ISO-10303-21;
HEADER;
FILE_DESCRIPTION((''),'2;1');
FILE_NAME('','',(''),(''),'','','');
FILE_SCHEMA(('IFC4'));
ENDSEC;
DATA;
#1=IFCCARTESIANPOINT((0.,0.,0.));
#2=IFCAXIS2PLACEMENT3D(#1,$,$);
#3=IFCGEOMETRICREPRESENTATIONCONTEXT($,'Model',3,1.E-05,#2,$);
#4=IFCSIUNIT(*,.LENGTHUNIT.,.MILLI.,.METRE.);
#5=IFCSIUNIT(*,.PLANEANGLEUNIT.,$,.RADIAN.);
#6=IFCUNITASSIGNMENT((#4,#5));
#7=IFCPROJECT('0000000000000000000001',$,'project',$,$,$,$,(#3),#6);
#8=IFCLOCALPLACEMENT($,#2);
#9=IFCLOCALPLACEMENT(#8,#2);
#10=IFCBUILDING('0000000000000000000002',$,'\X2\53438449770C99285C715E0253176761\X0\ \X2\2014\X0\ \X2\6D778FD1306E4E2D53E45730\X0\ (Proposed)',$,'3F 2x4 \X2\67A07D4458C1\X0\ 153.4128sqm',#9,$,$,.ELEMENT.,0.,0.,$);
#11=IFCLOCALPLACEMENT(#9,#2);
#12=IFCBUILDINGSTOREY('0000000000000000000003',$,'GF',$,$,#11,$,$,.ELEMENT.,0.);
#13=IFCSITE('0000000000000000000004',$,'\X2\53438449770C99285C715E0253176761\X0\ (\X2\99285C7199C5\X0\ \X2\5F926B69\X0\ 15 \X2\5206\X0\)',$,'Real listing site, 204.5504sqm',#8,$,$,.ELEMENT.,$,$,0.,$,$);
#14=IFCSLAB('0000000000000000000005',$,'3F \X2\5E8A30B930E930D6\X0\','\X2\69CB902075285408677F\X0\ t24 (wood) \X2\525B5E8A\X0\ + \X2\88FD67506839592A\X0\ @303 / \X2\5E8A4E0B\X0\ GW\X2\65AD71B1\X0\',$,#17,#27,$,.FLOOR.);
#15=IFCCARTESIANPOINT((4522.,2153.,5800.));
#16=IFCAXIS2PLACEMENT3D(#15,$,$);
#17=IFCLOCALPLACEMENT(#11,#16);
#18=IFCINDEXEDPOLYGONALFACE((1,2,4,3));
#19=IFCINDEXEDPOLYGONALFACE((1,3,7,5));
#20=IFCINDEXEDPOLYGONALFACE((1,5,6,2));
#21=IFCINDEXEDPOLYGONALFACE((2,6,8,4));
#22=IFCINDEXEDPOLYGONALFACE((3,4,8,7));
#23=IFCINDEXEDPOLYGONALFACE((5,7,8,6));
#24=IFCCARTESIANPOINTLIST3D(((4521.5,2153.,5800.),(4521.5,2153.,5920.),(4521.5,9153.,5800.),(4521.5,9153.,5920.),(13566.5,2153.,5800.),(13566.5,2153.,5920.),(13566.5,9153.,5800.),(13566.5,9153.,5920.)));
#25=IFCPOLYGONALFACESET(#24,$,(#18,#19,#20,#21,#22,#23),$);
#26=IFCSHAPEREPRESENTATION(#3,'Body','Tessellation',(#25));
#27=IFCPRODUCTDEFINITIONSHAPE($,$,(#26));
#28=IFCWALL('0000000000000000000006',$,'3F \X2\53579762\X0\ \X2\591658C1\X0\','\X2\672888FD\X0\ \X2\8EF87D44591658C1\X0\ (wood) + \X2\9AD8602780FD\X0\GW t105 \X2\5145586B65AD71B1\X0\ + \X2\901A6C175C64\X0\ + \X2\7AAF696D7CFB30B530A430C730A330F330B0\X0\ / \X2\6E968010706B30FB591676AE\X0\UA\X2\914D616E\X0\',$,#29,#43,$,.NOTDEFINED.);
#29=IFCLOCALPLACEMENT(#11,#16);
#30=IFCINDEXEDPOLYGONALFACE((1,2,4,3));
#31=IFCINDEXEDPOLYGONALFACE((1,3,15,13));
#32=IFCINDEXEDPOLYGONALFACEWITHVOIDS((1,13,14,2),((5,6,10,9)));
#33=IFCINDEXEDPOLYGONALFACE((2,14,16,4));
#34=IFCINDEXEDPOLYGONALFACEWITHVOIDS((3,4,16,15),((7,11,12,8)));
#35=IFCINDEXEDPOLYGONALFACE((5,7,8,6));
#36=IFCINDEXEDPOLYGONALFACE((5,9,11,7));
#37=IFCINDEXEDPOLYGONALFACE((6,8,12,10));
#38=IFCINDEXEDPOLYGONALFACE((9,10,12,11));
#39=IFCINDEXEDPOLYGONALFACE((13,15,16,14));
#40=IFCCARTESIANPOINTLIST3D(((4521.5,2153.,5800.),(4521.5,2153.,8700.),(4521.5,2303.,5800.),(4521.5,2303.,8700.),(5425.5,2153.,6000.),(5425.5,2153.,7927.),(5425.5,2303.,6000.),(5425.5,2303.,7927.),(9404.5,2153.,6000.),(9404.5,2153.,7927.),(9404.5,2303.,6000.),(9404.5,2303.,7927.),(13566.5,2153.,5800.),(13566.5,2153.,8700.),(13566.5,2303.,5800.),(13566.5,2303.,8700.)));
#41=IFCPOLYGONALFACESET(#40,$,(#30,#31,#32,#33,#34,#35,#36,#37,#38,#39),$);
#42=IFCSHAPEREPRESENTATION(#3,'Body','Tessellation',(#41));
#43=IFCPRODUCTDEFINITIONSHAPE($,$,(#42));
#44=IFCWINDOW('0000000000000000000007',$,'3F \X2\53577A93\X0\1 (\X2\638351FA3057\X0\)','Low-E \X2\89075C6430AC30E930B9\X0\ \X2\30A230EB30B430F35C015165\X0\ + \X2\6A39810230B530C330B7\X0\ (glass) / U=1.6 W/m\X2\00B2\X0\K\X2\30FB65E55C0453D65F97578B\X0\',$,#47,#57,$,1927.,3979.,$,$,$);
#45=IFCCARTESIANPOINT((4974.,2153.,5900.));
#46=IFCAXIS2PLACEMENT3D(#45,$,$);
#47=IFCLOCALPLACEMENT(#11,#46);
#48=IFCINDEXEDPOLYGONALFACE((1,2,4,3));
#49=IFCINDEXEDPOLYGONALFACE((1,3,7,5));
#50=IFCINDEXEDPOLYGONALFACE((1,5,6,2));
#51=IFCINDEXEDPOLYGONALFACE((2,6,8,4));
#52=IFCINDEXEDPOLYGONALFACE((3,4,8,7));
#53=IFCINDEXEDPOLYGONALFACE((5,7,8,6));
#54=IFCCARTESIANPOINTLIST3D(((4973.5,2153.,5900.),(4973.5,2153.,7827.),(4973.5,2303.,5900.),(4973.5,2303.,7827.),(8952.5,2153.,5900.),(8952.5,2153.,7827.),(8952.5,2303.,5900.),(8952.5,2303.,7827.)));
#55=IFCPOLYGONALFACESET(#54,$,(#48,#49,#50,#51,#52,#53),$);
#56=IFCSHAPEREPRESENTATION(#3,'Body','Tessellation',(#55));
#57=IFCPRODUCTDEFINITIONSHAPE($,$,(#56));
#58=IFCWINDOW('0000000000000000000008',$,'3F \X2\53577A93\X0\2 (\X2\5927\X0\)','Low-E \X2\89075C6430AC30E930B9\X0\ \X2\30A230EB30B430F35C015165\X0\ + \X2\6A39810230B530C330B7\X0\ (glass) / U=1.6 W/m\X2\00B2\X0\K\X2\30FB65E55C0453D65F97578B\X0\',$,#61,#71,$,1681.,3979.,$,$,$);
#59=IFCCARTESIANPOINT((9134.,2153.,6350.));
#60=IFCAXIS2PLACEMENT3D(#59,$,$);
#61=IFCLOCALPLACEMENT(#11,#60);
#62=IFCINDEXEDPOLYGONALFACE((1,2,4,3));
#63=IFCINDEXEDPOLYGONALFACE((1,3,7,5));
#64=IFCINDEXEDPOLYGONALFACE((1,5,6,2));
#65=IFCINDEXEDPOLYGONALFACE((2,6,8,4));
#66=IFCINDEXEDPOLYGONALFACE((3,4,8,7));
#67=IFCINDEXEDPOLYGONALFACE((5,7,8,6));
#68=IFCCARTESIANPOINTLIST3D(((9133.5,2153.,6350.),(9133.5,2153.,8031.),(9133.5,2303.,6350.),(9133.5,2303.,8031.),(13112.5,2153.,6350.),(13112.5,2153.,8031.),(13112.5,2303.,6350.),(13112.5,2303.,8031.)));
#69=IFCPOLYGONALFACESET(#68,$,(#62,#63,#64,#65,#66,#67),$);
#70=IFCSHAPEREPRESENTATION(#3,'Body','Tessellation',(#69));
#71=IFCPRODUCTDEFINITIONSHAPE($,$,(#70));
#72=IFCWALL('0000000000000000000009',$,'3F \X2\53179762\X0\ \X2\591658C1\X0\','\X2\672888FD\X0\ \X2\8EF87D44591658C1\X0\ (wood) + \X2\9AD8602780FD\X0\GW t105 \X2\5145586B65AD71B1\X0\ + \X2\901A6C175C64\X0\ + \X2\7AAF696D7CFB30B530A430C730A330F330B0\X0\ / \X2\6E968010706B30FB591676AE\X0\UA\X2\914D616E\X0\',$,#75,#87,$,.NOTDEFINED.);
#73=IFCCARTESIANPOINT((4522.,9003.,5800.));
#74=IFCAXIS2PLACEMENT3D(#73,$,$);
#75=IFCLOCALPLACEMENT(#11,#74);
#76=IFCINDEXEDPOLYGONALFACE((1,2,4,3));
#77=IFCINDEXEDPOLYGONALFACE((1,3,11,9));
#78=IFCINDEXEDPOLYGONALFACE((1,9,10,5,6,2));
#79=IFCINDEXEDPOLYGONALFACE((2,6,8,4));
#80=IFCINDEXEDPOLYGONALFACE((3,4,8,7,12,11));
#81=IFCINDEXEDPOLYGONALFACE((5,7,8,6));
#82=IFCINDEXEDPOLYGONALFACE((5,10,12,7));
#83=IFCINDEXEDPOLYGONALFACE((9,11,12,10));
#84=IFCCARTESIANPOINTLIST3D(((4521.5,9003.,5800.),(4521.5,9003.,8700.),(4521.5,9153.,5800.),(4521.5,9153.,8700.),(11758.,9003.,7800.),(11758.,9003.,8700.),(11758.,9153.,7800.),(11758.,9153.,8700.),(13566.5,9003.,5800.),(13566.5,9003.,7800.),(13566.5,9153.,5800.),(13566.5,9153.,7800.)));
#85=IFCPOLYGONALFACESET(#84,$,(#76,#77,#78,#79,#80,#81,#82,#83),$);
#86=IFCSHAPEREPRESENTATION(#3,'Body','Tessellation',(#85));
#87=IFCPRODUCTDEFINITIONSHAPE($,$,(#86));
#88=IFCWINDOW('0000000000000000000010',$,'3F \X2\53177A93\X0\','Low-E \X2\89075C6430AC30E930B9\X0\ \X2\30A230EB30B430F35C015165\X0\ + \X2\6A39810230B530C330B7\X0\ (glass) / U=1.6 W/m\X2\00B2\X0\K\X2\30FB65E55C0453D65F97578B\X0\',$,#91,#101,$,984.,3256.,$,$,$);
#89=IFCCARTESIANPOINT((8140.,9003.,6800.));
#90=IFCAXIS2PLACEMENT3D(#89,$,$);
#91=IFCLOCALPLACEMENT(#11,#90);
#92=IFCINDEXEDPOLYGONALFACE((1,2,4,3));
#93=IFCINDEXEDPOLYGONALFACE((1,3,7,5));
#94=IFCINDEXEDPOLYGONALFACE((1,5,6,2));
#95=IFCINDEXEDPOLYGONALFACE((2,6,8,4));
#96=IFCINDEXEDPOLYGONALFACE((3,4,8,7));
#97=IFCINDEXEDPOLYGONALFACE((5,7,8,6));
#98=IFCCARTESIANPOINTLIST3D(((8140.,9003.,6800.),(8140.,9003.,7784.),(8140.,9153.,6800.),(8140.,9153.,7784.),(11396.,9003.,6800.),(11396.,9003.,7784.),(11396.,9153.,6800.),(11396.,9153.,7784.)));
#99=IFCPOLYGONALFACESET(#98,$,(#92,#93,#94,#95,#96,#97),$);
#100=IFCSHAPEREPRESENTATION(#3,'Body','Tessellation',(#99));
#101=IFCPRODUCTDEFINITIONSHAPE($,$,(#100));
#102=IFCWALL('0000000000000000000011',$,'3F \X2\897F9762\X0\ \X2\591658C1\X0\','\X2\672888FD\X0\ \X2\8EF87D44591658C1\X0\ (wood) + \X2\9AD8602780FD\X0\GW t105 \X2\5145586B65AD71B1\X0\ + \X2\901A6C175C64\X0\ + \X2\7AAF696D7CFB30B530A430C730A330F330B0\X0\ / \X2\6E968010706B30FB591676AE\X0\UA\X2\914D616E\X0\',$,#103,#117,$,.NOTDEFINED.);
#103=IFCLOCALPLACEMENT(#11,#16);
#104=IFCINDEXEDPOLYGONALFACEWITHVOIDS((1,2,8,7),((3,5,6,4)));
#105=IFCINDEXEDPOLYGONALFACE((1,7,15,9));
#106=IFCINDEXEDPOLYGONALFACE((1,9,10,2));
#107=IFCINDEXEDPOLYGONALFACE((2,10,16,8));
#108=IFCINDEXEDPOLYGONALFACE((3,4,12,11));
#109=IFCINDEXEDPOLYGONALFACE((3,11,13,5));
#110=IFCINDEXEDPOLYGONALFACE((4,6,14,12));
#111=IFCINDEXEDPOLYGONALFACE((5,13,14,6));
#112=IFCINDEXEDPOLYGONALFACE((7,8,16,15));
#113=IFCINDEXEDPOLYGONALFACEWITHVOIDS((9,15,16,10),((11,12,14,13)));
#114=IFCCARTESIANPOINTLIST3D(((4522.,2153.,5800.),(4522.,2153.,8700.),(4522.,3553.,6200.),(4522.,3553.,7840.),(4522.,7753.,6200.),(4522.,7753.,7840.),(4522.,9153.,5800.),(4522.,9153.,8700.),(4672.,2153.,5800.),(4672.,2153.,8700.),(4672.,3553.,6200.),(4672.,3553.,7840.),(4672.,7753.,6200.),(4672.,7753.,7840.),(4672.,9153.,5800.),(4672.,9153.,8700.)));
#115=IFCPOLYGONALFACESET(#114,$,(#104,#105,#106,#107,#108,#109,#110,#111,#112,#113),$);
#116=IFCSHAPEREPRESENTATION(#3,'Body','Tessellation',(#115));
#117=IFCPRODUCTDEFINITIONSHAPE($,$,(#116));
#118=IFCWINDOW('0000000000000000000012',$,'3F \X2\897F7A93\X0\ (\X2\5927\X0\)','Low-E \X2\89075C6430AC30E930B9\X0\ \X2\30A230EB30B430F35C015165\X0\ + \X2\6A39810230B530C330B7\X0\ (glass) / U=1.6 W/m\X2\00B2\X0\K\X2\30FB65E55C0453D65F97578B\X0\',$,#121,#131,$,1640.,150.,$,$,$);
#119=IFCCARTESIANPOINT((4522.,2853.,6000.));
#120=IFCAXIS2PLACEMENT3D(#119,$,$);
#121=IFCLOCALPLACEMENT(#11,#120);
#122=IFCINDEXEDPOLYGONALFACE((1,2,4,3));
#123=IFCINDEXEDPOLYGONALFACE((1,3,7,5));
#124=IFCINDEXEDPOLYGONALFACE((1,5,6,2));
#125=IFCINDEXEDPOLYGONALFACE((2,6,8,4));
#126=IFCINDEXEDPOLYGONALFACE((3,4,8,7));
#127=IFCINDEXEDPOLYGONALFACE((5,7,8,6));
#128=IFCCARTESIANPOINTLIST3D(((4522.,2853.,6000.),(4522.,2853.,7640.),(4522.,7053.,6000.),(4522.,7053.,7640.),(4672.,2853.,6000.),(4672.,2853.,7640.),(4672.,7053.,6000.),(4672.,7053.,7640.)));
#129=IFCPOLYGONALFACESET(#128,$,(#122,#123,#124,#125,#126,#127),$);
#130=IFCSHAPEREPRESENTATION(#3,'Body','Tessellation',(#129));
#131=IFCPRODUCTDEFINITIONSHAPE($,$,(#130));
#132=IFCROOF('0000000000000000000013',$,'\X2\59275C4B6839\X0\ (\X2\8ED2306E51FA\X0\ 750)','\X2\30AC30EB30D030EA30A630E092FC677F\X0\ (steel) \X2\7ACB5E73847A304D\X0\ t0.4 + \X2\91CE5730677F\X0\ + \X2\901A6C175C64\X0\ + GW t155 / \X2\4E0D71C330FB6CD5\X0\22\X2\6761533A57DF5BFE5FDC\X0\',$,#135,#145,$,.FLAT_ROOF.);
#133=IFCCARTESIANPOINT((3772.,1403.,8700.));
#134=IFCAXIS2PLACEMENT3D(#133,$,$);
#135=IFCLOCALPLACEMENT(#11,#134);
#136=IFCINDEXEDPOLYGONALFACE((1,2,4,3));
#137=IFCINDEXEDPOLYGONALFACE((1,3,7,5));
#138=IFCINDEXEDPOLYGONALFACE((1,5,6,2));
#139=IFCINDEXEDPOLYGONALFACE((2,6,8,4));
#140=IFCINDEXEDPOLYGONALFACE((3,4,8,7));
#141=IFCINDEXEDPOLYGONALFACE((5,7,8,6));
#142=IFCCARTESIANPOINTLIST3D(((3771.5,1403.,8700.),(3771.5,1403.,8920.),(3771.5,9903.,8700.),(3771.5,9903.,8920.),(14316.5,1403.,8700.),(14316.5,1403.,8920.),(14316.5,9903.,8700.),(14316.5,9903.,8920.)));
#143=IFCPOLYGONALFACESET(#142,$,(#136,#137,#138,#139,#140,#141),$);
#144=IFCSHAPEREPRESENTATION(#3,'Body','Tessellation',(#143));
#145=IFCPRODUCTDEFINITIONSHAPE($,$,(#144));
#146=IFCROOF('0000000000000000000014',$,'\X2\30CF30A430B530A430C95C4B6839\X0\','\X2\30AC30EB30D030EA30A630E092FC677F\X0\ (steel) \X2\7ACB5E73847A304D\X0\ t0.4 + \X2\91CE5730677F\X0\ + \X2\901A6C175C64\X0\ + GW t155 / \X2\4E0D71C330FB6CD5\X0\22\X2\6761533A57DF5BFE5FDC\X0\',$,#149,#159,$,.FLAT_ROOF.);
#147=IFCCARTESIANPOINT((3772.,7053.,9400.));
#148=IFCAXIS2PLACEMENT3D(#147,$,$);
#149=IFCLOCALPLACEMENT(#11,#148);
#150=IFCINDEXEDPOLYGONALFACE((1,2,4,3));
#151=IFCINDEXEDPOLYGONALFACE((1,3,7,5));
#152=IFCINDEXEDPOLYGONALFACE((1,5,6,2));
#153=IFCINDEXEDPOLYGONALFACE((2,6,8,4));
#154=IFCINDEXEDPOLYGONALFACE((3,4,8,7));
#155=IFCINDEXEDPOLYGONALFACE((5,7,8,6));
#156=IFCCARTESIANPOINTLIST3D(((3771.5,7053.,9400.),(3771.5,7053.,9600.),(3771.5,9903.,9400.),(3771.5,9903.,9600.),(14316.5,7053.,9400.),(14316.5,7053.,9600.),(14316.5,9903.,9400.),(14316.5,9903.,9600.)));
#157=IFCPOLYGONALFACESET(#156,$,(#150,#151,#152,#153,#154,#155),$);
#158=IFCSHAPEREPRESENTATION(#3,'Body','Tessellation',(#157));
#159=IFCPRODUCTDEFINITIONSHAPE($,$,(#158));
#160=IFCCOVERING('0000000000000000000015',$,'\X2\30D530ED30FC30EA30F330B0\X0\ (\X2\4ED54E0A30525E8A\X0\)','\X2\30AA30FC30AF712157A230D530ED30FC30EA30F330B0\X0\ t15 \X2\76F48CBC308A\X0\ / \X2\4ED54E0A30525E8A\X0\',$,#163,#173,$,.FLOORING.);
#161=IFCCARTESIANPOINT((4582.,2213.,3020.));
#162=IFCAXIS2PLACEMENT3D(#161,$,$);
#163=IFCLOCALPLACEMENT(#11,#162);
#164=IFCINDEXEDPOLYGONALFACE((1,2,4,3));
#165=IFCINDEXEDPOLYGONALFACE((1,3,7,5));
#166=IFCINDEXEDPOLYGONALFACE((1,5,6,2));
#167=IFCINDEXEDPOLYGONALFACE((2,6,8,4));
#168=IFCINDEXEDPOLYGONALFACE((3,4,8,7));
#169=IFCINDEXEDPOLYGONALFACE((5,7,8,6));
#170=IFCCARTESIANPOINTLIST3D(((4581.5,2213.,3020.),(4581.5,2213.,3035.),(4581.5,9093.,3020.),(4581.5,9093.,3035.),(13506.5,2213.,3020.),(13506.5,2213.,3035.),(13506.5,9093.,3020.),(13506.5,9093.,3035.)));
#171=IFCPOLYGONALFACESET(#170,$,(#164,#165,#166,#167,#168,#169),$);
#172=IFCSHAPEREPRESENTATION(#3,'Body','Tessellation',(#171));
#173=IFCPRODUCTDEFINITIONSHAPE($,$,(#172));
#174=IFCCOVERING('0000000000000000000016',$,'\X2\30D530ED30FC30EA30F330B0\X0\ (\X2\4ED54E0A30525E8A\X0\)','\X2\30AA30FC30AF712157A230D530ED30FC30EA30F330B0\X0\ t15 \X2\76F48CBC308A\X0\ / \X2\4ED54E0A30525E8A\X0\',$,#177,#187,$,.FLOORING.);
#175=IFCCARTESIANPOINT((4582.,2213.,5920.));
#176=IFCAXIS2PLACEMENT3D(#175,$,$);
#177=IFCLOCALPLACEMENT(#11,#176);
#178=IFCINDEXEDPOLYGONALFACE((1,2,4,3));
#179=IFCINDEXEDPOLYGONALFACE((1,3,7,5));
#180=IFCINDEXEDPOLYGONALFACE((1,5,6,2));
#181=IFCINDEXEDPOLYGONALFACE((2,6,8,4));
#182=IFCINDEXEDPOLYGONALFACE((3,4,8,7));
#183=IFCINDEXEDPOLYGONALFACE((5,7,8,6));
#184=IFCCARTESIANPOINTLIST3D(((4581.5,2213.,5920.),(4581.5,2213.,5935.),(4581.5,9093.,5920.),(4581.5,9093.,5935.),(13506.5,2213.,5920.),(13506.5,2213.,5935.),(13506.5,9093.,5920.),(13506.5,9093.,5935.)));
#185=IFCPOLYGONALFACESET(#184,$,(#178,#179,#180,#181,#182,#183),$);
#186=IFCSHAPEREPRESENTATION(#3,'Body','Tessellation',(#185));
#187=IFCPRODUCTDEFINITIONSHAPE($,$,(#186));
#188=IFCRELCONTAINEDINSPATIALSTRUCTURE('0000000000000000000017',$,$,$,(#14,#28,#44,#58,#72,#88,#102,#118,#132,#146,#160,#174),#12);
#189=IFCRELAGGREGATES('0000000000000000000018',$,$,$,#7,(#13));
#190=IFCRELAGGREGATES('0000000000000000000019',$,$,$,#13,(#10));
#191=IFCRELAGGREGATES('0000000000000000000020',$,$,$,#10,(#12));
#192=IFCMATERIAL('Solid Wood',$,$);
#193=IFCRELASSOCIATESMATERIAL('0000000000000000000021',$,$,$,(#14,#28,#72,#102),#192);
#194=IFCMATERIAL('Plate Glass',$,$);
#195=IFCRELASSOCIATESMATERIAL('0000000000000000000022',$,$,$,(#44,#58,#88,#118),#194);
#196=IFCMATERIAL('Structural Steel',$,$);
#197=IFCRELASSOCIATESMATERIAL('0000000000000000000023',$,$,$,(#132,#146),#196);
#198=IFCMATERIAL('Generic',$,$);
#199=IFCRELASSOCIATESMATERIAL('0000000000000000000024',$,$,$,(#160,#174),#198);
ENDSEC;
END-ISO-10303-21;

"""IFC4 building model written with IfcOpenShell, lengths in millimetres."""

from ifc_helpers import new_model, si_unit, frame, frame_2d, origin, place, context, project, spatial, rectangle, extrude, material, element, fill, save


model = new_model("IFC4")

# Units and contexts
model_context = context("Model", 3, precision=1e-05, world=origin())
ifc_project = project(units=[si_unit("LENGTHUNIT", "METRE", prefix="MILLI"), si_unit("PLANEANGLEUNIT", "RADIAN")], contexts=[model_context])

# Site, building, storey
site_placement = place(None, origin())
site = spatial("IfcSite", under=ifc_project, at=site_placement, Name="千葉県館山市北条 (館山駅 徒歩 15 分)", ObjectType="Real listing site, 204.5504sqm", CompositionType="ELEMENT", RefElevation=0.0)
building_placement = place(site_placement, origin())
building = spatial("IfcBuilding", under=site, at=building_placement, Name="千葉県館山市北条 — 海近の中古地 (Proposed)", ObjectType="3F 2x4 枠組壁 153.4128sqm", CompositionType="ELEMENT", ElevationOfRefHeight=0.0, ElevationOfTerrain=0.0)
storey_placement = place(building_placement, origin())
storey = spatial("IfcBuildingStorey", under=building, at=storey_placement, Name="GF", CompositionType="ELEMENT", Elevation=0.0)

# Slab
ifc_material_1 = material(Name="Solid Wood")
slab_placement = place(storey_placement, frame((4522.0, 2153.0, 5800.0)))
element("IfcSlab", 1, at=slab_placement, inside=storey, material=ifc_material_1, Name="3F 床スラブ", Description="構造用合板 t24 (wood) 剛床 + 製材根太 @303 / 床下 GW断熱", PredefinedType="FLOOR", context=model_context, shape_type="SweptSolid", body=[
    extrude(rectangle(XDim=9045.0, YDim=7000.0, at=frame_2d((4522.0, 3500.0))), frame((4522.0, 2153.0, 5800.0)), (0.0, 0.0, 1.0), 120.0),
])

# Wall, openings, windows
wall_1_placement = place(storey_placement, frame((4522.0, 2153.0, 5800.0)))
wall_1 = element("IfcWall", 2, at=wall_1_placement, inside=storey, material=ifc_material_1, Name="3F 南面 外壁", Description="木製 軸組外壁 (wood) + 高性能GW t105 充填断熱 + 通気層 + 窯業系サイディング / 準耐火・外皮UA配慮", PredefinedType="NOTDEFINED", context=model_context, shape_type="SweptSolid", body=[
    extrude(rectangle(XDim=9045.0, YDim=150.0, at=frame_2d((4522.0, 75.0))), frame((4522.0, 2153.0, 5800.0)), (0.0, 0.0, 1.0), 2900.0),
])
opening_1_placement = place(storey_placement, frame((4974.0, 2153.0, 5900.0)))
opening_1 = element("IfcOpeningElement", 3, at=opening_1_placement, cuts=wall_1, PredefinedType="NOTDEFINED", context=model_context, shape_type="SweptSolid", body=[
    extrude(rectangle(XDim=3979.0, YDim=150.0, at=frame_2d((1989.0, 75.0))), frame((4974.0, 2153.0, 5900.0)), (0.0, 0.0, 1.0), 1927.0),
])
opening_2_placement = place(storey_placement, frame((9134.0, 2153.0, 6350.0)))
opening_2 = element("IfcOpeningElement", 4, at=opening_2_placement, cuts=wall_1, PredefinedType="NOTDEFINED", context=model_context, shape_type="SweptSolid", body=[
    extrude(rectangle(XDim=3979.0, YDim=150.0, at=frame_2d((1989.0, 75.0))), frame((9134.0, 2153.0, 6350.0)), (0.0, 0.0, 1.0), 1681.0),
])
ifc_material_2 = material(Name="Plate Glass")
window_1_placement = place(storey_placement, frame((4974.0, 2153.0, 5900.0)))
window_1 = element("IfcWindow", 5, at=window_1_placement, inside=storey, material=ifc_material_2, Name="3F 南窓1 (掃出し)", Description="Low-E 複層ガラス アルゴン封入 + 樹脂サッシ (glass) / U=1.6 W/m²K・日射取得型", OverallHeight=1927.0, OverallWidth=3979.0, context=model_context, shape_type="SweptSolid", body=[
    extrude(rectangle(XDim=3979.0, YDim=150.0, at=frame_2d((1989.0, 75.0))), frame((4974.0, 2153.0, 5900.0)), (0.0, 0.0, 1.0), 1927.0),
])
fill(opening_1, window_1)
window_2_placement = place(storey_placement, frame((9134.0, 2153.0, 6350.0)))
window_2 = element("IfcWindow", 6, at=window_2_placement, inside=storey, material=ifc_material_2, Name="3F 南窓2 (大)", Description="Low-E 複層ガラス アルゴン封入 + 樹脂サッシ (glass) / U=1.6 W/m²K・日射取得型", OverallHeight=1681.0, OverallWidth=3979.0, context=model_context, shape_type="SweptSolid", body=[
    extrude(rectangle(XDim=3979.0, YDim=150.0, at=frame_2d((1989.0, 75.0))), frame((9134.0, 2153.0, 6350.0)), (0.0, 0.0, 1.0), 1681.0),
])
fill(opening_2, window_2)

# Walls, openings, windows
wall_2_placement = place(storey_placement, frame((4522.0, 9003.0, 5800.0)))
wall_2 = element("IfcWall", 7, at=wall_2_placement, inside=storey, material=ifc_material_1, Name="3F 北面 外壁", Description="木製 軸組外壁 (wood) + 高性能GW t105 充填断熱 + 通気層 + 窯業系サイディング / 準耐火・外皮UA配慮", PredefinedType="NOTDEFINED", context=model_context, shape_type="SweptSolid", body=[
    extrude(rectangle(XDim=9045.0, YDim=150.0, at=frame_2d((4522.0, 75.0))), frame((4522.0, 9003.0, 5800.0)), (0.0, 0.0, 1.0), 2900.0),
])
opening_3_placement = place(storey_placement, frame((8140.0, 9003.0, 6800.0)))
opening_3 = element("IfcOpeningElement", 8, at=opening_3_placement, cuts=wall_2, PredefinedType="NOTDEFINED", context=model_context, shape_type="SweptSolid", body=[
    extrude(rectangle(XDim=3256.0, YDim=150.0, at=frame_2d((1628.0, 75.0))), frame((8140.0, 9003.0, 6800.0)), (0.0, 0.0, 1.0), 984.0),
])
window_3_placement = place(storey_placement, frame((8140.0, 9003.0, 6800.0)))
window_3 = element("IfcWindow", 9, at=window_3_placement, inside=storey, material=ifc_material_2, Name="3F 北窓", Description="Low-E 複層ガラス アルゴン封入 + 樹脂サッシ (glass) / U=1.6 W/m²K・日射取得型", OverallHeight=984.0, OverallWidth=3256.0, context=model_context, shape_type="SweptSolid", body=[
    extrude(rectangle(XDim=3256.0, YDim=150.0, at=frame_2d((1628.0, 75.0))), frame((8140.0, 9003.0, 6800.0)), (0.0, 0.0, 1.0), 984.0),
])
fill(opening_3, window_3)
wall_3_placement = place(storey_placement, frame((4522.0, 2153.0, 5800.0)))
wall_3 = element("IfcWall", 10, at=wall_3_placement, inside=storey, material=ifc_material_1, Name="3F 西面 外壁", Description="木製 軸組外壁 (wood) + 高性能GW t105 充填断熱 + 通気層 + 窯業系サイディング / 準耐火・外皮UA配慮", PredefinedType="NOTDEFINED", context=model_context, shape_type="SweptSolid", body=[
    extrude(rectangle(XDim=150.0, YDim=7000.0, at=frame_2d((75.0, 3500.0))), frame((4522.0, 2153.0, 5800.0)), (0.0, 0.0, 1.0), 2900.0),
])
opening_4_placement = place(storey_placement, frame((4522.0, 2853.0, 6000.0)))
opening_4 = element("IfcOpeningElement", 11, at=opening_4_placement, cuts=wall_3, PredefinedType="NOTDEFINED", context=model_context, shape_type="SweptSolid", body=[
    extrude(rectangle(XDim=150.0, YDim=4200.0, at=frame_2d((75.0, 2100.0))), frame((4522.0, 2853.0, 6000.0)), (0.0, 0.0, 1.0), 1640.0),
])
window_4_placement = place(storey_placement, frame((4522.0, 2853.0, 6000.0)))
window_4 = element("IfcWindow", 12, at=window_4_placement, inside=storey, material=ifc_material_2, Name="3F 西窓 (大)", Description="Low-E 複層ガラス アルゴン封入 + 樹脂サッシ (glass) / U=1.6 W/m²K・日射取得型", OverallHeight=1640.0, OverallWidth=150.0, context=model_context, shape_type="SweptSolid", body=[
    extrude(rectangle(XDim=150.0, YDim=4200.0, at=frame_2d((75.0, 2100.0))), frame((4522.0, 2853.0, 6000.0)), (0.0, 0.0, 1.0), 1640.0),
])
fill(opening_4, window_4)

# Roofs
ifc_material_3 = material(Name="Structural Steel")
roof_1_placement = place(storey_placement, frame((3772.0, 1403.0, 8700.0)))
element("IfcRoof", 13, at=roof_1_placement, inside=storey, material=ifc_material_3, Name="大屋根 (軒の出 750)", Description="ガルバリウム鋼板 (steel) 立平葺き t0.4 + 野地板 + 通気層 + GW t155 / 不燃・法22条区域対応", PredefinedType="FLAT_ROOF", context=model_context, shape_type="SweptSolid", body=[
    extrude(rectangle(XDim=10545.0, YDim=8500.0, at=frame_2d((5272.0, 4250.0))), frame((3772.0, 1403.0, 8700.0)), (0.0, 0.0, 1.0), 220.0),
])
roof_2_placement = place(storey_placement, frame((3772.0, 7053.0, 9400.0)))
element("IfcRoof", 14, at=roof_2_placement, inside=storey, material=ifc_material_3, Name="ハイサイド屋根", Description="ガルバリウム鋼板 (steel) 立平葺き t0.4 + 野地板 + 通気層 + GW t155 / 不燃・法22条区域対応", PredefinedType="FLAT_ROOF", context=model_context, shape_type="SweptSolid", body=[
    extrude(rectangle(XDim=10545.0, YDim=2850.0, at=frame_2d((5272.0, 1425.0))), frame((3772.0, 7053.0, 9400.0)), (0.0, 0.0, 1.0), 200.0),
])

# Coverings
ifc_material_4 = material(Name="Generic")
covering_1_placement = place(storey_placement, frame((4582.0, 2213.0, 3020.0)))
element("IfcCovering", 15, at=covering_1_placement, inside=storey, material=ifc_material_4, Name="フローリング (仕上げ床)", Description="オーク無垢フローリング t15 直貼り / 仕上げ床", PredefinedType="FLOORING", context=model_context, shape_type="SweptSolid", body=[
    extrude(rectangle(XDim=8925.0, YDim=6880.0, at=frame_2d((4462.0, 3440.0))), frame((4582.0, 2213.0, 3020.0)), (0.0, 0.0, 1.0), 15.0),
])
covering_2_placement = place(storey_placement, frame((4582.0, 2213.0, 5920.0)))
element("IfcCovering", 16, at=covering_2_placement, inside=storey, material=ifc_material_4, Name="フローリング (仕上げ床)", Description="オーク無垢フローリング t15 直貼り / 仕上げ床", PredefinedType="FLOORING", context=model_context, shape_type="SweptSolid", body=[
    extrude(rectangle(XDim=8925.0, YDim=6880.0, at=frame_2d((4462.0, 3440.0))), frame((4582.0, 2213.0, 5920.0)), (0.0, 0.0, 1.0), 15.0),
])

save(model, "model.ifc")
